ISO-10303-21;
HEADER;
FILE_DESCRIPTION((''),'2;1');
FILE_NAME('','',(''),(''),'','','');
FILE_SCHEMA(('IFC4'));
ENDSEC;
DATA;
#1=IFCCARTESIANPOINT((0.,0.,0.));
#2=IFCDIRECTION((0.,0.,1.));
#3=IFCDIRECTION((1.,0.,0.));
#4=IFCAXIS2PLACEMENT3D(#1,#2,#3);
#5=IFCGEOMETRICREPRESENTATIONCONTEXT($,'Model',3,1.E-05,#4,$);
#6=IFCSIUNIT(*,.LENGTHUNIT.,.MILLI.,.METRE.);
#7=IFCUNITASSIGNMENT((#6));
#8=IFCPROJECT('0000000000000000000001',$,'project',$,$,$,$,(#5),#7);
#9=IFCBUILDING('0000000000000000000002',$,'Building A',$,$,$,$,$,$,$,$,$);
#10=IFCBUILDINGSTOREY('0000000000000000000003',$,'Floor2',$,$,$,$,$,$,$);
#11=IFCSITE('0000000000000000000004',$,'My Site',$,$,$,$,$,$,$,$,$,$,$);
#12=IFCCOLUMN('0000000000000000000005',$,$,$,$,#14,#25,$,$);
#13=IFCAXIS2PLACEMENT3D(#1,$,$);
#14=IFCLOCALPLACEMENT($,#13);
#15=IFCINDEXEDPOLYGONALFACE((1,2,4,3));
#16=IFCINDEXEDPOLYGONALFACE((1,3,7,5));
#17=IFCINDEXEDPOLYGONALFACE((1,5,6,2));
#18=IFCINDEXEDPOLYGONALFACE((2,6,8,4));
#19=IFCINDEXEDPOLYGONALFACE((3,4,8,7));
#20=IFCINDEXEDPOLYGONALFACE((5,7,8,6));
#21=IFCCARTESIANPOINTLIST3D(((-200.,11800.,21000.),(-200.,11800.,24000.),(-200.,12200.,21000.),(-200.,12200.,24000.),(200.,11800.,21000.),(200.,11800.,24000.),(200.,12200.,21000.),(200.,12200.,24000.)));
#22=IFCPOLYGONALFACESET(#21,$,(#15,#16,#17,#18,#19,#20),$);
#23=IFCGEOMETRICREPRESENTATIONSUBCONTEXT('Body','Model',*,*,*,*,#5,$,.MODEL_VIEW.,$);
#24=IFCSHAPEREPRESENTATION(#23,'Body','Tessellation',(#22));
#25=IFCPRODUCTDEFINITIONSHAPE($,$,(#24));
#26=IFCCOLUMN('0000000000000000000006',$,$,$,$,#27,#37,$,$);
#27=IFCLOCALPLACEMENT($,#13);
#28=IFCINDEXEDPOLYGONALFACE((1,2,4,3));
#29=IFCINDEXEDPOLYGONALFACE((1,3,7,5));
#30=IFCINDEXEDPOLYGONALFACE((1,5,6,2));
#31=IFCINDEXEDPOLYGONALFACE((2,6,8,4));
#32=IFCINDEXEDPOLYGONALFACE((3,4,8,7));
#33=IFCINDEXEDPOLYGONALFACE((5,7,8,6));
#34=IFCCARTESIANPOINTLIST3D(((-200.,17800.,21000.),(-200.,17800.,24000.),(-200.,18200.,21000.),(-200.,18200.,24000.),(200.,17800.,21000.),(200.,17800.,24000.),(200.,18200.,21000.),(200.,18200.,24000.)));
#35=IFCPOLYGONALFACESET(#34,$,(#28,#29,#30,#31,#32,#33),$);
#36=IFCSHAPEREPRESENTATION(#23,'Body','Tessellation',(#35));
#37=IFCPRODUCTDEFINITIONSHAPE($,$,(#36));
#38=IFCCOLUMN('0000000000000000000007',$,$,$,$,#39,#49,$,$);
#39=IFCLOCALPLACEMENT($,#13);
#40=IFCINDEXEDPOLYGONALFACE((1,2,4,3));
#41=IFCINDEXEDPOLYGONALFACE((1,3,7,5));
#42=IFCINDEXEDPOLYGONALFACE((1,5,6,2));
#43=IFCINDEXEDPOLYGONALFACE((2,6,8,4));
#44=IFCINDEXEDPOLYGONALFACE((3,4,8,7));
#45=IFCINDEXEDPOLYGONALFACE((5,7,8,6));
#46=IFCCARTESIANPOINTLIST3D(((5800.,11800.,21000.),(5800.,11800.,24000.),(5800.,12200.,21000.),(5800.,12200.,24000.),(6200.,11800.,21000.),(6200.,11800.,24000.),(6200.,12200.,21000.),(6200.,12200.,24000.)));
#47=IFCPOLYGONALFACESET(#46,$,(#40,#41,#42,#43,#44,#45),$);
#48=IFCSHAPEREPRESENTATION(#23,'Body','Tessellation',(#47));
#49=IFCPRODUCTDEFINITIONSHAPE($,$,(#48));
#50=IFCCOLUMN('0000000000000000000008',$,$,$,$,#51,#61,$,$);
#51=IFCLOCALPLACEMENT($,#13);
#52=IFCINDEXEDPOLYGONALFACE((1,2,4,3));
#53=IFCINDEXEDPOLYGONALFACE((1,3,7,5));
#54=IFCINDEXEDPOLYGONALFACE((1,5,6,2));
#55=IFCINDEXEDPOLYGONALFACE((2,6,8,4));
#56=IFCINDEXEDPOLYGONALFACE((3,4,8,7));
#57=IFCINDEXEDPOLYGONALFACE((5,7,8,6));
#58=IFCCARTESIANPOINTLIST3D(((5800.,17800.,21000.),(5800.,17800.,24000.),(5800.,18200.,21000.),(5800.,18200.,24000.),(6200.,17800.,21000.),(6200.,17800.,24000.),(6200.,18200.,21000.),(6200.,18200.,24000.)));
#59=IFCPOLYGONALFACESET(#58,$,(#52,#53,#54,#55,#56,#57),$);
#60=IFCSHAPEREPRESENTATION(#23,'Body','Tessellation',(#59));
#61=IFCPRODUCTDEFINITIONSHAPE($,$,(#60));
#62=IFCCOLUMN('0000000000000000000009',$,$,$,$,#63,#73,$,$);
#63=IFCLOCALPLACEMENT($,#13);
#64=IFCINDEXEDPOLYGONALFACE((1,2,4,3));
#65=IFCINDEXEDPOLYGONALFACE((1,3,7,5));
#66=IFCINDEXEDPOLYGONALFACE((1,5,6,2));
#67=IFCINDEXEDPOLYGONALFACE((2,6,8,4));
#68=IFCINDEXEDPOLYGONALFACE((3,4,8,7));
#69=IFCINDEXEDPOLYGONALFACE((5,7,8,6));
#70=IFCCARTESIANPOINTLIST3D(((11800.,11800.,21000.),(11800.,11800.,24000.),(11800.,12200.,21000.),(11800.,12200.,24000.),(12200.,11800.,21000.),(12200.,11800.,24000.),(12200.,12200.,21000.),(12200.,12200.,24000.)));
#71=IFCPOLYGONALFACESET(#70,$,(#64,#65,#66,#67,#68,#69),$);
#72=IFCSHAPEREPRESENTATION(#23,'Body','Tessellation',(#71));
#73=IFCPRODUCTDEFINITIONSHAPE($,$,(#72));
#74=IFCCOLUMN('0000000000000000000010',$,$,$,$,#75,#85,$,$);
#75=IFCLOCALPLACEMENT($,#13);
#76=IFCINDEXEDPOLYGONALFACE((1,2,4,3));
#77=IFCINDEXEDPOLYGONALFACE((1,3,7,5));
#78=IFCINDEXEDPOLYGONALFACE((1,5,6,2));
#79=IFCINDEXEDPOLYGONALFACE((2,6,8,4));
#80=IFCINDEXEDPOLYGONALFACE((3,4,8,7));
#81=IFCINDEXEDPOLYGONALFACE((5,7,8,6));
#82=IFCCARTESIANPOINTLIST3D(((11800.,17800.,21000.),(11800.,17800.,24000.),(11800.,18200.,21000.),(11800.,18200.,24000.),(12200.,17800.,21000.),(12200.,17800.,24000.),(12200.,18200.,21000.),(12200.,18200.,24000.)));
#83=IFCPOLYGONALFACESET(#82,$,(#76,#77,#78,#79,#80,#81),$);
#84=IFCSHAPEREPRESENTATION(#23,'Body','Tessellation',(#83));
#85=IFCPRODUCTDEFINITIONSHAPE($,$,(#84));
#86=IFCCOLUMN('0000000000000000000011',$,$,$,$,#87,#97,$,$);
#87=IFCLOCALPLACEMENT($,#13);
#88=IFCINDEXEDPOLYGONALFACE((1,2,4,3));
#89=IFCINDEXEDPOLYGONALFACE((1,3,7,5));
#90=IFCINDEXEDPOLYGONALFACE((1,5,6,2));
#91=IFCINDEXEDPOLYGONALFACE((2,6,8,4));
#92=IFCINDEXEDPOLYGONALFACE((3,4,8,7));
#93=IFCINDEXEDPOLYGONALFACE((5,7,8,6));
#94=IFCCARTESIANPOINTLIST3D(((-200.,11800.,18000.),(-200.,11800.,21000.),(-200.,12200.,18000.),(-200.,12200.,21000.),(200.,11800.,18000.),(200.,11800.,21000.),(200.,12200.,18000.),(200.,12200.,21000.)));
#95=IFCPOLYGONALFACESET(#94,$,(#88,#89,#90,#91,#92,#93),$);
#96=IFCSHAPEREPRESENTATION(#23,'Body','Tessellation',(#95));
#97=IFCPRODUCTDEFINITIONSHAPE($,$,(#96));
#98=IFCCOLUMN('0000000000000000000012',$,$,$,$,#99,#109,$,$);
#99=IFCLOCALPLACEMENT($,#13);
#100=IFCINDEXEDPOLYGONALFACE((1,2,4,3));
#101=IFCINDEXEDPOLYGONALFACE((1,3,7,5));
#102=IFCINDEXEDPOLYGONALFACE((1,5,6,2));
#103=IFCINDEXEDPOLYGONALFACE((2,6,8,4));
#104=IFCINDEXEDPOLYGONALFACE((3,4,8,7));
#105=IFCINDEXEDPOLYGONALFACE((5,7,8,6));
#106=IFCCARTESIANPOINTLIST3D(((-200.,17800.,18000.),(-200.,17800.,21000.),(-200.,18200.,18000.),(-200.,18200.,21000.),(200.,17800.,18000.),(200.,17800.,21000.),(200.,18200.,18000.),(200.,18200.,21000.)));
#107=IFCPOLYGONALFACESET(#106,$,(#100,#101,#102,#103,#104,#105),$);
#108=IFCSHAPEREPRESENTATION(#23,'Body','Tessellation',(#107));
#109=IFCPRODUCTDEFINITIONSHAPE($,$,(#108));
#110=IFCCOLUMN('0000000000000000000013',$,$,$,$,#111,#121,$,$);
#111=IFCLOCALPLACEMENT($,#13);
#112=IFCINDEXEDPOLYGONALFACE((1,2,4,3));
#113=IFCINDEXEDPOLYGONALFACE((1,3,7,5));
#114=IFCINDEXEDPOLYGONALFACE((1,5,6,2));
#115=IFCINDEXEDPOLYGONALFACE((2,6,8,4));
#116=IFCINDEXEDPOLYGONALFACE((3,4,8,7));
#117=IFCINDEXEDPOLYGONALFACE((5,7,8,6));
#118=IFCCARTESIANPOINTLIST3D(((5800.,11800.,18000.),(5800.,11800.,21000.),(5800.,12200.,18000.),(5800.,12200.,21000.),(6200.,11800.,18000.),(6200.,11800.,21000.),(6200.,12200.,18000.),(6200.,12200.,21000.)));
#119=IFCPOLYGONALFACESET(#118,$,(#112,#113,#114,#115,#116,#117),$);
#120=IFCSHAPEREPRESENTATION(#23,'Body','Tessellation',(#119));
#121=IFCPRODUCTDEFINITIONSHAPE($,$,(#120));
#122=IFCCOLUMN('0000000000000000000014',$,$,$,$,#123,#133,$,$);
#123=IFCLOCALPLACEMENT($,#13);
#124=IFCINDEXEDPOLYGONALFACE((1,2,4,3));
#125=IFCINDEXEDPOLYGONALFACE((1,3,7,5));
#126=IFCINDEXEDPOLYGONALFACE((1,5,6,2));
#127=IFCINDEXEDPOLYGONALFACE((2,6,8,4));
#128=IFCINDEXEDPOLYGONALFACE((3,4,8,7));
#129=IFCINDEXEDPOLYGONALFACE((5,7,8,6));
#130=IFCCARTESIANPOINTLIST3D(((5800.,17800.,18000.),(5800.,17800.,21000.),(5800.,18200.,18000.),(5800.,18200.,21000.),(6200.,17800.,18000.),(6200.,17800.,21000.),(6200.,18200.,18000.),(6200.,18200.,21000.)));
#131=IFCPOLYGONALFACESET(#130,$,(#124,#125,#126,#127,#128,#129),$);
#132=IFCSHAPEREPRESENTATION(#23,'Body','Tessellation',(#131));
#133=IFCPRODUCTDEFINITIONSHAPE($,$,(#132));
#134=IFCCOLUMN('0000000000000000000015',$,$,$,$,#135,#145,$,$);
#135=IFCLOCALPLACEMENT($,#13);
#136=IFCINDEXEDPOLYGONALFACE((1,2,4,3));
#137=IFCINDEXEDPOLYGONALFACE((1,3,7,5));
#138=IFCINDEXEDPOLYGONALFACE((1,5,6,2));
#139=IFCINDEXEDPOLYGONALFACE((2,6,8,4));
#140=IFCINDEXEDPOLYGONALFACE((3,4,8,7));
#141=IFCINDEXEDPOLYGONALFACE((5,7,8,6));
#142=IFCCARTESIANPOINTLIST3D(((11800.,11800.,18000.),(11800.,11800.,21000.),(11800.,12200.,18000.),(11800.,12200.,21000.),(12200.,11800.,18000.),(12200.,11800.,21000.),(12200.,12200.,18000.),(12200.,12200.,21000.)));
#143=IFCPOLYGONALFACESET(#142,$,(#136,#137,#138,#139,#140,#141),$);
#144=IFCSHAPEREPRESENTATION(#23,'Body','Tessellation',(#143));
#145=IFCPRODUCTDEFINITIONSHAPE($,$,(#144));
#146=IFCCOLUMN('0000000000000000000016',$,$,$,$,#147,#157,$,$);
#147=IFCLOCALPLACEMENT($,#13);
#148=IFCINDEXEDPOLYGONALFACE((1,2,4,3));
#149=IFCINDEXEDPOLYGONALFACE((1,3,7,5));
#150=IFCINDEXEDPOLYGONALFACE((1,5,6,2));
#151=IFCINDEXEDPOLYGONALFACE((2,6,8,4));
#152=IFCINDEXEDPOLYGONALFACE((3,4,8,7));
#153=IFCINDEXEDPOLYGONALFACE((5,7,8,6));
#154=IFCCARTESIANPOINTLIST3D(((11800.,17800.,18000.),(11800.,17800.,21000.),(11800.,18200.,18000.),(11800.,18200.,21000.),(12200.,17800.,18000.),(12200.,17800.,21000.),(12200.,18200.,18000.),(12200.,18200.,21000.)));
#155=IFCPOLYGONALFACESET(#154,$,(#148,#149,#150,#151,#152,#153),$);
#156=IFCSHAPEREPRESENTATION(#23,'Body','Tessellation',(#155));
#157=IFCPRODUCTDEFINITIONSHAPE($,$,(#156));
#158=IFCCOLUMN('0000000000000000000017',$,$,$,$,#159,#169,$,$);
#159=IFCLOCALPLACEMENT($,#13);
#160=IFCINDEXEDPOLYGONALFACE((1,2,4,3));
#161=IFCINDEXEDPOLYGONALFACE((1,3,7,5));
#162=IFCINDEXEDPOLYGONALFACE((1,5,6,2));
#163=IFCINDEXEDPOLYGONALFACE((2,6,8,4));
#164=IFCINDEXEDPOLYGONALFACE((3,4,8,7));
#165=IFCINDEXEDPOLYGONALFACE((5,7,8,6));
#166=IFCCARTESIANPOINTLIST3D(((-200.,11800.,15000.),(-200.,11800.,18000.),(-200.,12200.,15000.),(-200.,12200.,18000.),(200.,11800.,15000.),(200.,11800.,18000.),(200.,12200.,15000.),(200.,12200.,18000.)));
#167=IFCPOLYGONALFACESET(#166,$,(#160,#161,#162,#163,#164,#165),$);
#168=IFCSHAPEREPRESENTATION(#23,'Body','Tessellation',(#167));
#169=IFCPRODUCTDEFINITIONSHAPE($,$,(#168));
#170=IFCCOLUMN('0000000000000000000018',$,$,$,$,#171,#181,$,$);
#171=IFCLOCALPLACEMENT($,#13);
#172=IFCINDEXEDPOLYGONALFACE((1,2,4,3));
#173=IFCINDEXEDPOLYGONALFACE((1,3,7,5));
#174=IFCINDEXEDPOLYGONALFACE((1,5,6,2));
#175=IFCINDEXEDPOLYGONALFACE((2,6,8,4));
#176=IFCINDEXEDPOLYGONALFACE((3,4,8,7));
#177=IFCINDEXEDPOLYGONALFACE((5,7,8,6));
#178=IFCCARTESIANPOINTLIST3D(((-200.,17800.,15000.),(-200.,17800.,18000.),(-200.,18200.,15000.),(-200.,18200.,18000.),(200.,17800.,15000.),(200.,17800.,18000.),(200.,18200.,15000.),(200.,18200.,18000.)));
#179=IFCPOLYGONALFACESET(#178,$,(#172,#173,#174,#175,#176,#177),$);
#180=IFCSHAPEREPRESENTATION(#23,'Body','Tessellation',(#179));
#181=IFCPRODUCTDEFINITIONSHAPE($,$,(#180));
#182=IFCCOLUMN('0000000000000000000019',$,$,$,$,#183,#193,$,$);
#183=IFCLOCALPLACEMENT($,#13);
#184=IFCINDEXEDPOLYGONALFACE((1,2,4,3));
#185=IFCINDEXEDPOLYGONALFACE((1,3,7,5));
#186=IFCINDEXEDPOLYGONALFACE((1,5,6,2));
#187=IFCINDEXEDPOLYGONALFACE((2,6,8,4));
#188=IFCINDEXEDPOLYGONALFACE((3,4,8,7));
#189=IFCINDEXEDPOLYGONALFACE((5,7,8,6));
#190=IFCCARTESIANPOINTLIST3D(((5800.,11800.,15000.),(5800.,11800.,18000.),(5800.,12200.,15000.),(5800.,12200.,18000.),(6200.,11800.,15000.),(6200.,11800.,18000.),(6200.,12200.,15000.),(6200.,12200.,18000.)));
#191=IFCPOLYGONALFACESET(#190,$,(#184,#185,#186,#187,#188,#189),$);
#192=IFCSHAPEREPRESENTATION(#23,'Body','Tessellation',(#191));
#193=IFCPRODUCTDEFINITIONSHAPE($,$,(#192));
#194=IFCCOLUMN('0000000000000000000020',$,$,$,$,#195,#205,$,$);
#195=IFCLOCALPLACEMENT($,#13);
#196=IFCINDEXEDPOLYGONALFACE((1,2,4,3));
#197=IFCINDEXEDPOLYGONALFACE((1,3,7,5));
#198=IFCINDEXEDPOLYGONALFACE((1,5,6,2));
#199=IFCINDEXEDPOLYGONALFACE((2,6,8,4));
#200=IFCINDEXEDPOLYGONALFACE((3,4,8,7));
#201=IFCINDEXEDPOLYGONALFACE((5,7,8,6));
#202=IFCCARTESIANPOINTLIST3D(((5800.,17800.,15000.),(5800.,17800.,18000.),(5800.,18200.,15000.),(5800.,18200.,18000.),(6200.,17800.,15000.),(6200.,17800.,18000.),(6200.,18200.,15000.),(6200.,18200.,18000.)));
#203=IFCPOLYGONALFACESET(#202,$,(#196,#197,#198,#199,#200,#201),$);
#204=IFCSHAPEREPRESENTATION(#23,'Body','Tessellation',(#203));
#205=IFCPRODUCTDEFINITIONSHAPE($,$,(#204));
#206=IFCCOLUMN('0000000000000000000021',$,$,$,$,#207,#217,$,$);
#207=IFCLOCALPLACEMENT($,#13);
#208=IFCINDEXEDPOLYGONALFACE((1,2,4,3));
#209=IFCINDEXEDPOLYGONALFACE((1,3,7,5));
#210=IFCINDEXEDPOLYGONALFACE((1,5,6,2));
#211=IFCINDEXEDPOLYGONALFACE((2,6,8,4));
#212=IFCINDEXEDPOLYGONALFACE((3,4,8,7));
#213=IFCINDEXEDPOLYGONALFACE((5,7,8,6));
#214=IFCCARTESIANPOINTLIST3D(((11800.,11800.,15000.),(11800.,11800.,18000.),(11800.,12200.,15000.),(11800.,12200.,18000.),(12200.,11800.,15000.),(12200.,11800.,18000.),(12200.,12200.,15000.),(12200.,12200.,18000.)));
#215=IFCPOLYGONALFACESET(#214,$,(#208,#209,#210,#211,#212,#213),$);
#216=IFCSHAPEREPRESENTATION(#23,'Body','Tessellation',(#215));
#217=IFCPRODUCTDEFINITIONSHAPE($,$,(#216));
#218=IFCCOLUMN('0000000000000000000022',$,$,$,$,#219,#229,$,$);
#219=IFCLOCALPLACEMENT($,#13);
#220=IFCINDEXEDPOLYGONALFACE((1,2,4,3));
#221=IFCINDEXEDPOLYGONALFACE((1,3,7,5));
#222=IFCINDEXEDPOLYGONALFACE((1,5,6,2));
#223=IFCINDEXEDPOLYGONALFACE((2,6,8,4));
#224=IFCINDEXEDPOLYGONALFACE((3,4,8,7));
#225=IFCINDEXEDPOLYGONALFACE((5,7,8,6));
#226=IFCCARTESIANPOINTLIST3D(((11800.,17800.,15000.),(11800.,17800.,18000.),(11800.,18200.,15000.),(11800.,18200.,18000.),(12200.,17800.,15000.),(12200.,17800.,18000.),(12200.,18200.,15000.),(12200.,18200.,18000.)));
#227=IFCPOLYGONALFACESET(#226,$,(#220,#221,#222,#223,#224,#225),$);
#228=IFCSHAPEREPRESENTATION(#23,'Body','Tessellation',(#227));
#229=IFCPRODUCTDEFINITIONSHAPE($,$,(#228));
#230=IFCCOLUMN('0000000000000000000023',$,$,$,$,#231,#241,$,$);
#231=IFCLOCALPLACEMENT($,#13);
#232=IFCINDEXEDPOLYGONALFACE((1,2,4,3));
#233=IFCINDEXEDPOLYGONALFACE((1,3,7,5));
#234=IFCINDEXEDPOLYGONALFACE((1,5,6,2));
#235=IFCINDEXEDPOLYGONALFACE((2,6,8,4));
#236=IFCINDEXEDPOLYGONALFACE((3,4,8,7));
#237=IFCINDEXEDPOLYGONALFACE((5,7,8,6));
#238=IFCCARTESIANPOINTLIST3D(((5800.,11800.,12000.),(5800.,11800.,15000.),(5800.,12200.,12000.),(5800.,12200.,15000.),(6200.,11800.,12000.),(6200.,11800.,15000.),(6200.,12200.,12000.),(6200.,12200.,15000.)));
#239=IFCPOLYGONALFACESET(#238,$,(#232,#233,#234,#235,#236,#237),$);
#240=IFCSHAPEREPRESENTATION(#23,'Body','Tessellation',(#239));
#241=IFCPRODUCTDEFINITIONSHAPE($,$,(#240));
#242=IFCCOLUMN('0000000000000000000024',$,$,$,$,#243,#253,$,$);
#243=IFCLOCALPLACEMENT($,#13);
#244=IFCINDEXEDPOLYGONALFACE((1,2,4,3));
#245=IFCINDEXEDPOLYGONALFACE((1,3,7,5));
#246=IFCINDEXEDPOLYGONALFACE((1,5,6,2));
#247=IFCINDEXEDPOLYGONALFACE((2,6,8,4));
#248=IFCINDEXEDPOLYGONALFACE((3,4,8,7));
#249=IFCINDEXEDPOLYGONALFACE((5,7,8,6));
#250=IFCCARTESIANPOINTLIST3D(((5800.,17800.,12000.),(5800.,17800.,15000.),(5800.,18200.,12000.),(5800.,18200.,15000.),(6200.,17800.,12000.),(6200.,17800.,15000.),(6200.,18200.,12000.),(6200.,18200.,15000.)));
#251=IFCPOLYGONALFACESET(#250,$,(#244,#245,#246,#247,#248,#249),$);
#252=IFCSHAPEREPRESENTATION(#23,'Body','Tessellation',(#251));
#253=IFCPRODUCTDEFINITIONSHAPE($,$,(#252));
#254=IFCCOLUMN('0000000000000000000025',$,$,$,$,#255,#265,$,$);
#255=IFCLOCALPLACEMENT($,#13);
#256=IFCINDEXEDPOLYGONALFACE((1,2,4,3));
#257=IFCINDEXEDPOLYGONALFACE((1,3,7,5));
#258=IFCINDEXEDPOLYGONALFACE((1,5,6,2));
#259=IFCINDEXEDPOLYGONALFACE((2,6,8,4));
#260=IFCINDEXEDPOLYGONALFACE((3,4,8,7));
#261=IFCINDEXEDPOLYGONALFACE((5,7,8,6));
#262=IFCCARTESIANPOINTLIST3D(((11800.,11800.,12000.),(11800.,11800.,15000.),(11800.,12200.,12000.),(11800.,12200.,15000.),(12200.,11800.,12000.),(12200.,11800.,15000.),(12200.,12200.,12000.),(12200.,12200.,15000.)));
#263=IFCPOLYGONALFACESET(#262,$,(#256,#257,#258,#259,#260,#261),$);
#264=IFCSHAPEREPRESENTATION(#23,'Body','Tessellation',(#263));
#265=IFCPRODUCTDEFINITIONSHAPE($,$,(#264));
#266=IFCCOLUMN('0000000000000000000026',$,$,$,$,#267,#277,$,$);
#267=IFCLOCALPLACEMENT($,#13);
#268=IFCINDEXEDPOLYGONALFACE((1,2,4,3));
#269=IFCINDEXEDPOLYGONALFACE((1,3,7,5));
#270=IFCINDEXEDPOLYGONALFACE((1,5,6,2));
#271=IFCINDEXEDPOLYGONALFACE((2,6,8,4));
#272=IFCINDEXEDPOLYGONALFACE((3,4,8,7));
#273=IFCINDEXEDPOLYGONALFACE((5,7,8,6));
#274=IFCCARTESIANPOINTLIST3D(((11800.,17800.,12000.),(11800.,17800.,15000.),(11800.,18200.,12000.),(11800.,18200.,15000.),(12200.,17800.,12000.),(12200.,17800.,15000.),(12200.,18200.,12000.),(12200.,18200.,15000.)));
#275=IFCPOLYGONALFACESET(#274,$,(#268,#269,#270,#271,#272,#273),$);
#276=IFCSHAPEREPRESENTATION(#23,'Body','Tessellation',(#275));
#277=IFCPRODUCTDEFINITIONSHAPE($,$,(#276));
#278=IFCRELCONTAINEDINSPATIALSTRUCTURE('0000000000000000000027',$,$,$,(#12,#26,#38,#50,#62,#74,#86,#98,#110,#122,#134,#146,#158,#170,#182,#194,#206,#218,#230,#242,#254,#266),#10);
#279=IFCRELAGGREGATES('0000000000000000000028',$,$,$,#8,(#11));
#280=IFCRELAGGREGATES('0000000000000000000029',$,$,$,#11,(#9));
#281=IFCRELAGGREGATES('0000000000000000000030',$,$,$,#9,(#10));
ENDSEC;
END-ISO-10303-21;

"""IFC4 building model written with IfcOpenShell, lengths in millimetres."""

from ifc_helpers import new_model, si_unit, frame, origin_with_axes, place, context, subcontext, project, spatial, line, indexed_curve, outline, extrude, element, save


model = new_model("IFC4")

# Units and contexts
model_context = context("Model", 3, precision=1e-05, world=origin_with_axes())
body_context = subcontext(model_context, "Body", "Model", "MODEL_VIEW")
ifc_project = project(units=[si_unit("LENGTHUNIT", "METRE", prefix="MILLI")], contexts=[model_context])

# Site, building, storey
site = spatial("IfcSite", under=ifc_project, Name="My Site")
building = spatial("IfcBuilding", under=site, Name="Building A")
storey = spatial("IfcBuildingStorey", under=building, Name="Floor2")

# Columns
for number, where, z_axis, x_axis in (
    (1, (0.0, 12000.0, 21000.0), (0.0, 0.0, 1.0), (1.0, 0.0, 0.0)),
    (2, (0.0, 18000.0, 21000.0), (0.0, 0.0, 1.0), (1.0, 0.0, 0.0)),
    (3, (6000.0, 12000.0, 21000.0), (0.0, 0.0, 1.0), (1.0, 0.0, 0.0)),
    (4, (6000.0, 18000.0, 21000.0), (0.0, 0.0, 1.0), (1.0, 0.0, 0.0)),
    (5, (12000.0, 12000.0, 21000.0), (0.0, 0.0, 1.0), (1.0, 0.0, 0.0)),
    (6, (12000.0, 18000.0, 21000.0), (0.0, 0.0, 1.0), (1.0, 0.0, 0.0)),
    (7, (0.0, 12000.0, 18000.0), (0.0, 0.0, 1.0), (1.0, 0.0, 0.0)),
    (8, (0.0, 18000.0, 18000.0), (0.0, 0.0, 1.0), (1.0, 0.0, 0.0)),
    (9, (6000.0, 12000.0, 18000.0), (0.0, 0.0, 1.0), (1.0, 0.0, 0.0)),
    (10, (6000.0, 18000.0, 18000.0), (0.0, 0.0, 1.0), (1.0, 0.0, 0.0)),
    (11, (12000.0, 12000.0, 18000.0), (0.0, 0.0, 1.0), (1.0, 0.0, 0.0)),
    (12, (12000.0, 18000.0, 18000.0), (0.0, 0.0, 1.0), (1.0, 0.0, 0.0)),
    (13, (0.0, 12000.0, 15000.0), (0.0, 0.0, 1.0), (1.0, 0.0, 0.0)),
    (14, (0.0, 18000.0, 15000.0), (0.0, 0.0, 1.0), (1.0, 0.0, 0.0)),
    (15, (6000.0, 12000.0, 15000.0), (0.0, 0.0, 1.0), (1.0, 0.0, 0.0)),
    (16, (6000.0, 18000.0, 15000.0), (0.0, 0.0, 1.0), (1.0, 0.0, 0.0)),
    (17, (12000.0, 12000.0, 15000.0), (0.0, 0.0, 1.0), (1.0, 0.0, 0.0)),
    (18, (12000.0, 18000.0, 15000.0), (0.0, 0.0, 1.0), (1.0, 0.0, 0.0)),
    (19, (6000.0, 12000.0, 12000.0), (0.0, 0.0, 1.0), (1.0, 0.0, 0.0)),
    (20, (6000.0, 18000.0, 12000.0), (0.0, 0.0, 1.0), (1.0, 0.0, 0.0)),
    (21, (12000.0, 12000.0, 12000.0), (0.0, 0.0, 1.0), (1.0, 0.0, 0.0)),
    (22, (12000.0, 18000.0, 12000.0), (0.0, 0.0, 1.0), (1.0, 0.0, 0.0)),
):
    element("IfcColumn", number, at=place(None, frame(where, z_axis=z_axis, x_axis=x_axis)), inside=storey, context=body_context, shape_type="SweptSolid", body=[
        extrude(outline(indexed_curve([(-200.0, -200.0), (200.0, -200.0), (200.0, 200.0), (-200.0, 200.0)], segments=[line(1, 2, 3, 4, 1)])), origin_with_axes(), (0.0, 0.0, 1.0), 3000.0),
    ])

save(model, "model.ifc")
